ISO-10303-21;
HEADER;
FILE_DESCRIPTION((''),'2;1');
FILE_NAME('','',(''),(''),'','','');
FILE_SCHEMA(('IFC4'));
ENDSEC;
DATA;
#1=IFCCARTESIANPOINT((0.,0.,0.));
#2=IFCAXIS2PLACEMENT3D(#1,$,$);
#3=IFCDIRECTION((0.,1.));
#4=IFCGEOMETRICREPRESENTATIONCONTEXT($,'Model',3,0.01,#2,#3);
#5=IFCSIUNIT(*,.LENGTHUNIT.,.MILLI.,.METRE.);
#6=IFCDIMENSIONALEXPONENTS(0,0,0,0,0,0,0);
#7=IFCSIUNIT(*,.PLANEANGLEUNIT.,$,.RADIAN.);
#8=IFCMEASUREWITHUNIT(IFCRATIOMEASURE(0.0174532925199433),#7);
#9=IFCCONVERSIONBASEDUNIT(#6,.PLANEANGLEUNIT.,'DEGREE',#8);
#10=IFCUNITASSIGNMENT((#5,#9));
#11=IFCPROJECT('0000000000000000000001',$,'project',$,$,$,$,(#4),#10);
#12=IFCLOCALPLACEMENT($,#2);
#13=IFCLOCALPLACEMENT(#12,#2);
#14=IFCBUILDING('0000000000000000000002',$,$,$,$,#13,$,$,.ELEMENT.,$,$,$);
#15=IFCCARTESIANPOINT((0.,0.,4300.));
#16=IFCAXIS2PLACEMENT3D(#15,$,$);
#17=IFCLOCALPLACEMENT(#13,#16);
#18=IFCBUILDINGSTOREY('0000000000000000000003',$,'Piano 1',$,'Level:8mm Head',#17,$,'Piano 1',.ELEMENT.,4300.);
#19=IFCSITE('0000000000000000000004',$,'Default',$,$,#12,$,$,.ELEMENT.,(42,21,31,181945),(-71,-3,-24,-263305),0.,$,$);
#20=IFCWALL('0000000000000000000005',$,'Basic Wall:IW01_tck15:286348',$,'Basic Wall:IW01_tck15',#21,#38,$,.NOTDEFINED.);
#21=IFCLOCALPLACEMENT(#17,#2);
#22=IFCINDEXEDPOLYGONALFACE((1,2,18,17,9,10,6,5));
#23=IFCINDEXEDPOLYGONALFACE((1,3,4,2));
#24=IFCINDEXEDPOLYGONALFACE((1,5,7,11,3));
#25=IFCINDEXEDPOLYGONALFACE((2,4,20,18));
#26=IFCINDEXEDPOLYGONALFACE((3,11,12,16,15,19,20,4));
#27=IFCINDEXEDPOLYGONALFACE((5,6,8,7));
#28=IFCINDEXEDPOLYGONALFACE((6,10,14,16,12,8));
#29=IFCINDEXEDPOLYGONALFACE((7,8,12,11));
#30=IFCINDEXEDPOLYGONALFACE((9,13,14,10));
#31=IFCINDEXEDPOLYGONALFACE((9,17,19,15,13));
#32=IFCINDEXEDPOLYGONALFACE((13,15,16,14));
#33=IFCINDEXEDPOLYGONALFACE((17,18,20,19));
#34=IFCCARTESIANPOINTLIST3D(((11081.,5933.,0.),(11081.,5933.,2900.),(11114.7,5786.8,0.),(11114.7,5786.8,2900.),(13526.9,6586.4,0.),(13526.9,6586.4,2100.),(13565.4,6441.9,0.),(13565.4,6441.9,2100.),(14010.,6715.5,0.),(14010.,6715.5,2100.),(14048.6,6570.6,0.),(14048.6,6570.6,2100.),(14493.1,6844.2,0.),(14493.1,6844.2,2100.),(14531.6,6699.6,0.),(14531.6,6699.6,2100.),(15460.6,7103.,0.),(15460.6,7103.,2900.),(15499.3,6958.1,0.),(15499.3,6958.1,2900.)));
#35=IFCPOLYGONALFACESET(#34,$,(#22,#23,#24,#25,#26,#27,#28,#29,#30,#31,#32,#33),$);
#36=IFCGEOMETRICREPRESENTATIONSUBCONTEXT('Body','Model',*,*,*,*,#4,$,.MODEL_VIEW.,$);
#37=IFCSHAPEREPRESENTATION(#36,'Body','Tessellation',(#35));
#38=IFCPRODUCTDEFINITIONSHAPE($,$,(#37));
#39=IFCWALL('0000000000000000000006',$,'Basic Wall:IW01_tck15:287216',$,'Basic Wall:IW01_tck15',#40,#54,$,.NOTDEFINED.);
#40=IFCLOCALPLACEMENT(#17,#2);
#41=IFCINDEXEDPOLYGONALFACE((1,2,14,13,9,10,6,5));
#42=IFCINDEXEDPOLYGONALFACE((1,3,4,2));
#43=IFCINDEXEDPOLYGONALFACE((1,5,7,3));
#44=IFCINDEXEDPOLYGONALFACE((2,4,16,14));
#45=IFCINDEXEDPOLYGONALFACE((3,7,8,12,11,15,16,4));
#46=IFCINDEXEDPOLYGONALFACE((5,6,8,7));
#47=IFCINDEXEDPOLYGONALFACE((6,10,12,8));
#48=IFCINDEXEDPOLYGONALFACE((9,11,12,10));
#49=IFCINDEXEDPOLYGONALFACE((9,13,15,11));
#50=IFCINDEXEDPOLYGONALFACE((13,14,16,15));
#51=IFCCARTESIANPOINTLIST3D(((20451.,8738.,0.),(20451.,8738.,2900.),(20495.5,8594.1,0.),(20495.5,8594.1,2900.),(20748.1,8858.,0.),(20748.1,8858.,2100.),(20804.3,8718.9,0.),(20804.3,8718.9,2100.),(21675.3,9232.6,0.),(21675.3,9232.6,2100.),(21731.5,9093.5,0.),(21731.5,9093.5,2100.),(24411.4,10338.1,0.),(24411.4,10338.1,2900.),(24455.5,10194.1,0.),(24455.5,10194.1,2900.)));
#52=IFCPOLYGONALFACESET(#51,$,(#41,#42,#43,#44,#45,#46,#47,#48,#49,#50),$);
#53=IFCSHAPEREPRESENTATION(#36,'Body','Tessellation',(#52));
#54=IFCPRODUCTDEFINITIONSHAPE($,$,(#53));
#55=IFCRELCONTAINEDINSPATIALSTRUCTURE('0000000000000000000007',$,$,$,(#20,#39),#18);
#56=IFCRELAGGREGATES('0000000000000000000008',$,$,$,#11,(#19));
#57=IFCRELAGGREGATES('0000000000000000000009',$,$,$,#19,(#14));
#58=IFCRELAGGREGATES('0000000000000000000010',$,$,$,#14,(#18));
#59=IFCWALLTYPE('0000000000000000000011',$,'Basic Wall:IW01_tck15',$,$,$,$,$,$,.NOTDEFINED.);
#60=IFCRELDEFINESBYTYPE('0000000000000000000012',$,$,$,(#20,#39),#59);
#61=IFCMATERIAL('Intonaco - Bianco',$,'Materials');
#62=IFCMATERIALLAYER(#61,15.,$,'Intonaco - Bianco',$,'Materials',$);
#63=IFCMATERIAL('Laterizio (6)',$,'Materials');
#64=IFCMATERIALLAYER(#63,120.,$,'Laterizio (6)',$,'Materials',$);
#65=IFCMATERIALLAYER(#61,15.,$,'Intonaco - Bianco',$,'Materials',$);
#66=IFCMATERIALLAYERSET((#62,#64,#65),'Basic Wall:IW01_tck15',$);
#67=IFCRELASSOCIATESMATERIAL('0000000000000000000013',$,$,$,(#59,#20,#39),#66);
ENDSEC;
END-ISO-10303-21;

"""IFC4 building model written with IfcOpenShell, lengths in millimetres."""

from ifc_helpers import new_model, entity, si_unit, converted_unit, direction, frame, frame_2d, origin, place, context, subcontext, project, spatial, polyline, rectangle, outline, extrude, clip, bounded_halfspace, material, layer, layer_set, layer_usage, type_object, element, save


model = new_model("IFC4")

# Units and contexts
model_context = context("Model", 3, precision=0.01, world=origin(), true_north=direction((0.0, 1.0)))
body_context = subcontext(model_context, "Body", "Model", "MODEL_VIEW")
ifc_project = project(units=[si_unit("LENGTHUNIT", "METRE", prefix="MILLI"), converted_unit("PLANEANGLEUNIT", "DEGREE", entity("IfcRatioMeasure", 0.0174532925199433), si_unit("PLANEANGLEUNIT", "RADIAN"), dimensions=[0, 0, 0, 0, 0, 0, 0])], contexts=[model_context])

# Site, building, storey
site_placement = place(None, origin())
site = spatial("IfcSite", under=ifc_project, at=site_placement, Name="Default", CompositionType="ELEMENT", RefLatitude=(42, 21, 31, 181945), RefLongitude=(-71, -3, -24, -263305), RefElevation=0.0)
building_placement = place(site_placement, origin())
building = spatial("IfcBuilding", under=site, at=building_placement, CompositionType="ELEMENT")
storey_placement = place(building_placement, frame((0.0, 0.0, 4300.0)))
storey = spatial("IfcBuildingStorey", under=building, at=storey_placement, Name="Piano 1", ObjectType="Level:8mm Head", LongName="Piano 1", CompositionType="ELEMENT", Elevation=4300.0)

# Walls, openings
ifc_material_1 = material(Name="Intonaco - Bianco", Category="Materials")
ifc_layer_1 = layer(ifc_material_1, 15.0, Name="Intonaco - Bianco", Category="Materials")
ifc_material_2 = material(Name="Laterizio (6)", Category="Materials")
ifc_layer_2 = layer(ifc_material_2, 120.0, Name="Laterizio (6)", Category="Materials")
ifc_layer_3 = layer(ifc_material_1, 15.0, Name="Intonaco - Bianco", Category="Materials")
ifc_layer_set_1 = layer_set([ifc_layer_1, ifc_layer_2, ifc_layer_3], Name="Basic Wall:IW01_tck15")
ifc_layer_usage_1 = layer_usage(ifc_layer_set_1, "AXIS2", "NEGATIVE", 75.0)
wall_type_1 = type_object("IfcWallType", Name="Basic Wall:IW01_tck15", PredefinedType="NOTDEFINED", material=ifc_layer_set_1)
wall_1_placement = place(storey_placement, frame((11095.4, 5859.2, 0.0), z_axis=(0.0, 0.0, 1.0), x_axis=(0.966117, 0.258104, 0.0)))
wall_1 = element("IfcWall", 1, at=wall_1_placement, inside=storey, type_object=wall_type_1, material=ifc_layer_usage_1, Name="Basic Wall:IW01_tck15:286348", ObjectType="Basic Wall:IW01_tck15", PredefinedType="NOTDEFINED", context=body_context, shape_type="Clipping", body=[
    clip(extrude(outline(polyline([(0.0, -75.0), (4538.4, -75.0), (4538.4, 75.0), (5.1, 75.0), (0.0, -75.0)])), origin(), (0.0, 0.0, 1.0), 2900.0), bounded_halfspace(frame((0.0, -75.0, 2900.0), z_axis=(0.0, 0.0, -1.0), x_axis=(0.999914, 0.013131, 0.0)), True, frame((0.0, -75.0, 2900.0)), polyline([(0.0, 0.0), (4538.4, 0.0), (4538.4, 150.0), (5.1, 150.0), (0.0, 0.0)]))),
])
opening_1_placement = place(wall_1_placement, frame((3536.9, 74.6, 0.0)))
element("IfcOpeningElement", 2, at=opening_1_placement, cuts=wall_1, ObjectType="Opening", PredefinedType="OPENING", context=body_context, shape_type="SweptSolid", body=[
    extrude(rectangle(XDim=2100.0, YDim=1000.0, at=frame_2d((1050.0, 500.0), x_axis=(1.0, 0.0))), frame((0.0, 0.0, 0.0), z_axis=(-0.00074, -1.0, 0.0), x_axis=(0.0, 0.0, 1.0)), (0.0, 0.0, 1.0), 150.0),
])
ifc_layer_usage_2 = layer_usage(ifc_layer_set_1, "AXIS2", "NEGATIVE", 75.0)
wall_2_placement = place(storey_placement, frame((20467.4, 8663.7, 0.0), z_axis=(0.0, 0.0, 1.0), x_axis=(0.927184, 0.374607, 0.0)))
wall_2 = element("IfcWall", 3, at=wall_2_placement, inside=storey, type_object=wall_type_1, material=ifc_layer_usage_2, Name="Basic Wall:IW01_tck15:287216", ObjectType="Basic Wall:IW01_tck15", PredefinedType="NOTDEFINED", context=body_context, shape_type="Clipping", body=[
    clip(extrude(outline(polyline([(0.0, -75.0), (4271.0, -75.0), (4284.1, 75.0), (1783.1, 75.0), (1633.1, 75.0), (12.7, 75.0), (0.0, -75.0)])), origin(), (0.0, 0.0, 1.0), 2900.0), bounded_halfspace(frame((0.0, -75.0, 2900.0), z_axis=(0.0, 0.0, -1.0), x_axis=(0.99398, -0.109562, 0.0)), True, frame((0.0, -75.0, 2900.0)), polyline([(0.0, 0.0), (4271.0, 0.0), (4284.1, 150.0), (1783.1, 150.0), (1633.1, 150.0), (12.7, 150.0), (0.0, 0.0)]))),
])
opening_2_placement = place(wall_2_placement, frame((1333.1, 75.0, 0.0)))
element("IfcOpeningElement", 4, at=opening_2_placement, cuts=wall_2, ObjectType="Opening", PredefinedType="OPENING", context=body_context, shape_type="SweptSolid", body=[
    extrude(rectangle(XDim=2100.0, YDim=1000.0, at=frame_2d((1050.0, 500.0), x_axis=(1.0, 0.0))), frame((0.0, 0.0, 0.0), z_axis=(0.0, -1.0, 0.0), x_axis=(0.0, 0.0, 1.0)), (0.0, 0.0, 1.0), 150.0),
])

save(model, "model.ifc")
